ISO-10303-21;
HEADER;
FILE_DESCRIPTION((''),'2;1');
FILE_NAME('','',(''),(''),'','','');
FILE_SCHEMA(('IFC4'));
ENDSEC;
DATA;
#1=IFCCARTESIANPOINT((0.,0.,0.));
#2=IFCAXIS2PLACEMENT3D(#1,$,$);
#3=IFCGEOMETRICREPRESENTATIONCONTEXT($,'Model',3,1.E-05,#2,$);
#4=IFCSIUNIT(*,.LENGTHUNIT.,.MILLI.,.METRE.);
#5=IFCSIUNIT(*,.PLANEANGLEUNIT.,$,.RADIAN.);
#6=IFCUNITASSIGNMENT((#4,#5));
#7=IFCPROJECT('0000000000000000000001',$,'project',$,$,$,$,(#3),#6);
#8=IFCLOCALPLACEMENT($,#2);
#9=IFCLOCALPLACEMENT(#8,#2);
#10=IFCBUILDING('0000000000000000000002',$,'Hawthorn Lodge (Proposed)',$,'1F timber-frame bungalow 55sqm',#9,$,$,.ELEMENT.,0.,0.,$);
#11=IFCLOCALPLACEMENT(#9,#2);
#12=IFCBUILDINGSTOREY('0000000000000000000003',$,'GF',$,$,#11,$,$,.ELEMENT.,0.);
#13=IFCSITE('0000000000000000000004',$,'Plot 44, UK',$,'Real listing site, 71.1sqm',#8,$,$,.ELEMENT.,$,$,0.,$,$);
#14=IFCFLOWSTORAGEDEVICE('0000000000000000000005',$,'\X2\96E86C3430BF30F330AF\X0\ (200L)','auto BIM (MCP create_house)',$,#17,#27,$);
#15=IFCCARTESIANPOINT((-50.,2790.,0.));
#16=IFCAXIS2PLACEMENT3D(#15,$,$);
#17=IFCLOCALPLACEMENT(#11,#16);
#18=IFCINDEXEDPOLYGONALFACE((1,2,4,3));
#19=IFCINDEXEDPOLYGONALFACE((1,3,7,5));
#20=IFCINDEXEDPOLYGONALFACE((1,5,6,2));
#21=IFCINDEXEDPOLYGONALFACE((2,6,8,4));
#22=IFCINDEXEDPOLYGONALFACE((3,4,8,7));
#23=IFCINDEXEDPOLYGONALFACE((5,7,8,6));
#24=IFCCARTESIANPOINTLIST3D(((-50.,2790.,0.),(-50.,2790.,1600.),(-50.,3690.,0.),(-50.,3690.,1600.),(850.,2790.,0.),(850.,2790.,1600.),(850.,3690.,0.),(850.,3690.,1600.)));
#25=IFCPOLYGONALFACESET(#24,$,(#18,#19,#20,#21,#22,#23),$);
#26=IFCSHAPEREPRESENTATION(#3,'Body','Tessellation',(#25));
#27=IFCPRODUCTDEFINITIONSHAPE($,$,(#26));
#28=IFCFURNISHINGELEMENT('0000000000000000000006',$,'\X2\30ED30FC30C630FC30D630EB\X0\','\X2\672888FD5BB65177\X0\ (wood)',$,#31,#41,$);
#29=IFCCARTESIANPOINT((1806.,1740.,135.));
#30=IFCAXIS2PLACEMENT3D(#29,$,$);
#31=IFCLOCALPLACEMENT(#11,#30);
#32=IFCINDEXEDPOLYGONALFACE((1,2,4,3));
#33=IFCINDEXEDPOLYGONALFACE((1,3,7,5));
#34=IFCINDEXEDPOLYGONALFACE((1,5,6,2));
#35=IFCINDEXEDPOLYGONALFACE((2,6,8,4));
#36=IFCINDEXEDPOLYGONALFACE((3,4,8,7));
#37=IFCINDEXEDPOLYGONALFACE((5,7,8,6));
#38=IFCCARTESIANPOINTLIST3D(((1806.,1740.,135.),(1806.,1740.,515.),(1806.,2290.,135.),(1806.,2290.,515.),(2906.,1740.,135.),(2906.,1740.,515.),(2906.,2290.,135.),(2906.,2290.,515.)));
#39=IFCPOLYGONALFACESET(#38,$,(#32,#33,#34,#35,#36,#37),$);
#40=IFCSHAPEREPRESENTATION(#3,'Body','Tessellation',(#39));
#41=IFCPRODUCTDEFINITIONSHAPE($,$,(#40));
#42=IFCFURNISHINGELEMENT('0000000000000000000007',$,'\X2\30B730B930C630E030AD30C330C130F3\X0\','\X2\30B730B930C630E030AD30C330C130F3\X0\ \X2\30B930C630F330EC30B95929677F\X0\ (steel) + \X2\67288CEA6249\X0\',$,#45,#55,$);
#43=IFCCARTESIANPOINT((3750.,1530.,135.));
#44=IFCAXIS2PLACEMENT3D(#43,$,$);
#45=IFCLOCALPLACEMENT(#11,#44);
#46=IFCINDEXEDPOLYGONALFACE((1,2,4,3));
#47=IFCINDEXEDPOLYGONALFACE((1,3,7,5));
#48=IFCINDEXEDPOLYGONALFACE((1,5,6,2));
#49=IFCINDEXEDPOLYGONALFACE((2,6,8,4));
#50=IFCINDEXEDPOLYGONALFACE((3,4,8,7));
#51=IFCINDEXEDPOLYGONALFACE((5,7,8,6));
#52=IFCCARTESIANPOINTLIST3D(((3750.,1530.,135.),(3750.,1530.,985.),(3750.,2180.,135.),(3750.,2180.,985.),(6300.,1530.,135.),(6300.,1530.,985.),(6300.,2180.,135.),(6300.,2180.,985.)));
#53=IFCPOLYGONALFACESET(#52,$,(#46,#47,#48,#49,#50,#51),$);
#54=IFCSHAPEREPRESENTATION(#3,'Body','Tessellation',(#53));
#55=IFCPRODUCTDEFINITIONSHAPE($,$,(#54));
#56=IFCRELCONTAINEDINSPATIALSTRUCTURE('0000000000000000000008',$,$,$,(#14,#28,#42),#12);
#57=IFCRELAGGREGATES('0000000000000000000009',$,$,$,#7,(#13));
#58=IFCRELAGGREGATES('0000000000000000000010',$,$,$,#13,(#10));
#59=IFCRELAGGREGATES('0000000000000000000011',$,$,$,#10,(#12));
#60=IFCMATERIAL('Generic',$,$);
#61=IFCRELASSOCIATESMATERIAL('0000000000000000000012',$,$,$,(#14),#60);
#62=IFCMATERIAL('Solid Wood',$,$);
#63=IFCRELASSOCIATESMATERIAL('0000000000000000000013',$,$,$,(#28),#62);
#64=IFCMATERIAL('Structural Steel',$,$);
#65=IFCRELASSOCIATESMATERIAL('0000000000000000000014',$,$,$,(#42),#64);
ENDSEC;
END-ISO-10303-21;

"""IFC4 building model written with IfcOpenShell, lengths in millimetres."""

from ifc_helpers import new_model, si_unit, frame, frame_2d, origin, place, context, project, spatial, rectangle, extrude, material, element, save


model = new_model("IFC4")

# Units and contexts
model_context = context("Model", 3, precision=1e-05, world=origin())
ifc_project = project(units=[si_unit("LENGTHUNIT", "METRE", prefix="MILLI"), si_unit("PLANEANGLEUNIT", "RADIAN")], contexts=[model_context])

# Site, building, storey
site_placement = place(None, origin())
site = spatial("IfcSite", under=ifc_project, at=site_placement, Name="Plot 44, UK", ObjectType="Real listing site, 71.1sqm", CompositionType="ELEMENT", RefElevation=0.0)
building_placement = place(site_placement, origin())
building = spatial("IfcBuilding", under=site, at=building_placement, Name="Hawthorn Lodge (Proposed)", ObjectType="1F timber-frame bungalow 55sqm", CompositionType="ELEMENT", ElevationOfRefHeight=0.0, ElevationOfTerrain=0.0)
storey_placement = place(building_placement, origin())
storey = spatial("IfcBuildingStorey", under=building, at=storey_placement, Name="GF", CompositionType="ELEMENT", Elevation=0.0)

# Shared definitions
ifc_material_1 = material(Name="Solid Wood")

# Shared definitions
ifc_material_2 = material(Name="Generic")

# Flow storage device
flow_storage_device_placement = place(storey_placement, frame((-50.0, 2790.0, 0.0)))
element("IfcFlowStorageDevice", 1, at=flow_storage_device_placement, inside=storey, material=ifc_material_2, Name="雨水タンク (200L)", Description="auto BIM (MCP create_house)", context=model_context, shape_type="SweptSolid", body=[
    extrude(rectangle(XDim=900.0, YDim=900.0, at=frame_2d((450.0, 450.0))), frame((-50.0, 2790.0, 0.0)), (0.0, 0.0, 1.0), 1600.0),
])

# Furnishing elements
furnishing_1_placement = place(storey_placement, frame((1806.0, 1740.0, 135.0)))
element("IfcFurnishingElement", 2, at=furnishing_1_placement, inside=storey, material=ifc_material_1, Name="ローテーブル", Description="木製家具 (wood)", context=model_context, shape_type="SweptSolid", body=[
    extrude(rectangle(XDim=1100.0, YDim=550.0, at=frame_2d((550.0, 275.0))), frame((1806.0, 1740.0, 135.0)), (0.0, 0.0, 1.0), 380.0),
])
ifc_material_3 = material(Name="Structural Steel")
furnishing_2_placement = place(storey_placement, frame((3750.0, 1530.0, 135.0)))
element("IfcFurnishingElement", 3, at=furnishing_2_placement, inside=storey, material=ifc_material_3, Name="システムキッチン", Description="システムキッチン ステンレス天板 (steel) + 木質扉", context=model_context, shape_type="SweptSolid", body=[
    extrude(rectangle(XDim=2550.0, YDim=650.0, at=frame_2d((1275.0, 325.0))), frame((3750.0, 1530.0, 135.0)), (0.0, 0.0, 1.0), 850.0),
])

save(model, "model.ifc")
